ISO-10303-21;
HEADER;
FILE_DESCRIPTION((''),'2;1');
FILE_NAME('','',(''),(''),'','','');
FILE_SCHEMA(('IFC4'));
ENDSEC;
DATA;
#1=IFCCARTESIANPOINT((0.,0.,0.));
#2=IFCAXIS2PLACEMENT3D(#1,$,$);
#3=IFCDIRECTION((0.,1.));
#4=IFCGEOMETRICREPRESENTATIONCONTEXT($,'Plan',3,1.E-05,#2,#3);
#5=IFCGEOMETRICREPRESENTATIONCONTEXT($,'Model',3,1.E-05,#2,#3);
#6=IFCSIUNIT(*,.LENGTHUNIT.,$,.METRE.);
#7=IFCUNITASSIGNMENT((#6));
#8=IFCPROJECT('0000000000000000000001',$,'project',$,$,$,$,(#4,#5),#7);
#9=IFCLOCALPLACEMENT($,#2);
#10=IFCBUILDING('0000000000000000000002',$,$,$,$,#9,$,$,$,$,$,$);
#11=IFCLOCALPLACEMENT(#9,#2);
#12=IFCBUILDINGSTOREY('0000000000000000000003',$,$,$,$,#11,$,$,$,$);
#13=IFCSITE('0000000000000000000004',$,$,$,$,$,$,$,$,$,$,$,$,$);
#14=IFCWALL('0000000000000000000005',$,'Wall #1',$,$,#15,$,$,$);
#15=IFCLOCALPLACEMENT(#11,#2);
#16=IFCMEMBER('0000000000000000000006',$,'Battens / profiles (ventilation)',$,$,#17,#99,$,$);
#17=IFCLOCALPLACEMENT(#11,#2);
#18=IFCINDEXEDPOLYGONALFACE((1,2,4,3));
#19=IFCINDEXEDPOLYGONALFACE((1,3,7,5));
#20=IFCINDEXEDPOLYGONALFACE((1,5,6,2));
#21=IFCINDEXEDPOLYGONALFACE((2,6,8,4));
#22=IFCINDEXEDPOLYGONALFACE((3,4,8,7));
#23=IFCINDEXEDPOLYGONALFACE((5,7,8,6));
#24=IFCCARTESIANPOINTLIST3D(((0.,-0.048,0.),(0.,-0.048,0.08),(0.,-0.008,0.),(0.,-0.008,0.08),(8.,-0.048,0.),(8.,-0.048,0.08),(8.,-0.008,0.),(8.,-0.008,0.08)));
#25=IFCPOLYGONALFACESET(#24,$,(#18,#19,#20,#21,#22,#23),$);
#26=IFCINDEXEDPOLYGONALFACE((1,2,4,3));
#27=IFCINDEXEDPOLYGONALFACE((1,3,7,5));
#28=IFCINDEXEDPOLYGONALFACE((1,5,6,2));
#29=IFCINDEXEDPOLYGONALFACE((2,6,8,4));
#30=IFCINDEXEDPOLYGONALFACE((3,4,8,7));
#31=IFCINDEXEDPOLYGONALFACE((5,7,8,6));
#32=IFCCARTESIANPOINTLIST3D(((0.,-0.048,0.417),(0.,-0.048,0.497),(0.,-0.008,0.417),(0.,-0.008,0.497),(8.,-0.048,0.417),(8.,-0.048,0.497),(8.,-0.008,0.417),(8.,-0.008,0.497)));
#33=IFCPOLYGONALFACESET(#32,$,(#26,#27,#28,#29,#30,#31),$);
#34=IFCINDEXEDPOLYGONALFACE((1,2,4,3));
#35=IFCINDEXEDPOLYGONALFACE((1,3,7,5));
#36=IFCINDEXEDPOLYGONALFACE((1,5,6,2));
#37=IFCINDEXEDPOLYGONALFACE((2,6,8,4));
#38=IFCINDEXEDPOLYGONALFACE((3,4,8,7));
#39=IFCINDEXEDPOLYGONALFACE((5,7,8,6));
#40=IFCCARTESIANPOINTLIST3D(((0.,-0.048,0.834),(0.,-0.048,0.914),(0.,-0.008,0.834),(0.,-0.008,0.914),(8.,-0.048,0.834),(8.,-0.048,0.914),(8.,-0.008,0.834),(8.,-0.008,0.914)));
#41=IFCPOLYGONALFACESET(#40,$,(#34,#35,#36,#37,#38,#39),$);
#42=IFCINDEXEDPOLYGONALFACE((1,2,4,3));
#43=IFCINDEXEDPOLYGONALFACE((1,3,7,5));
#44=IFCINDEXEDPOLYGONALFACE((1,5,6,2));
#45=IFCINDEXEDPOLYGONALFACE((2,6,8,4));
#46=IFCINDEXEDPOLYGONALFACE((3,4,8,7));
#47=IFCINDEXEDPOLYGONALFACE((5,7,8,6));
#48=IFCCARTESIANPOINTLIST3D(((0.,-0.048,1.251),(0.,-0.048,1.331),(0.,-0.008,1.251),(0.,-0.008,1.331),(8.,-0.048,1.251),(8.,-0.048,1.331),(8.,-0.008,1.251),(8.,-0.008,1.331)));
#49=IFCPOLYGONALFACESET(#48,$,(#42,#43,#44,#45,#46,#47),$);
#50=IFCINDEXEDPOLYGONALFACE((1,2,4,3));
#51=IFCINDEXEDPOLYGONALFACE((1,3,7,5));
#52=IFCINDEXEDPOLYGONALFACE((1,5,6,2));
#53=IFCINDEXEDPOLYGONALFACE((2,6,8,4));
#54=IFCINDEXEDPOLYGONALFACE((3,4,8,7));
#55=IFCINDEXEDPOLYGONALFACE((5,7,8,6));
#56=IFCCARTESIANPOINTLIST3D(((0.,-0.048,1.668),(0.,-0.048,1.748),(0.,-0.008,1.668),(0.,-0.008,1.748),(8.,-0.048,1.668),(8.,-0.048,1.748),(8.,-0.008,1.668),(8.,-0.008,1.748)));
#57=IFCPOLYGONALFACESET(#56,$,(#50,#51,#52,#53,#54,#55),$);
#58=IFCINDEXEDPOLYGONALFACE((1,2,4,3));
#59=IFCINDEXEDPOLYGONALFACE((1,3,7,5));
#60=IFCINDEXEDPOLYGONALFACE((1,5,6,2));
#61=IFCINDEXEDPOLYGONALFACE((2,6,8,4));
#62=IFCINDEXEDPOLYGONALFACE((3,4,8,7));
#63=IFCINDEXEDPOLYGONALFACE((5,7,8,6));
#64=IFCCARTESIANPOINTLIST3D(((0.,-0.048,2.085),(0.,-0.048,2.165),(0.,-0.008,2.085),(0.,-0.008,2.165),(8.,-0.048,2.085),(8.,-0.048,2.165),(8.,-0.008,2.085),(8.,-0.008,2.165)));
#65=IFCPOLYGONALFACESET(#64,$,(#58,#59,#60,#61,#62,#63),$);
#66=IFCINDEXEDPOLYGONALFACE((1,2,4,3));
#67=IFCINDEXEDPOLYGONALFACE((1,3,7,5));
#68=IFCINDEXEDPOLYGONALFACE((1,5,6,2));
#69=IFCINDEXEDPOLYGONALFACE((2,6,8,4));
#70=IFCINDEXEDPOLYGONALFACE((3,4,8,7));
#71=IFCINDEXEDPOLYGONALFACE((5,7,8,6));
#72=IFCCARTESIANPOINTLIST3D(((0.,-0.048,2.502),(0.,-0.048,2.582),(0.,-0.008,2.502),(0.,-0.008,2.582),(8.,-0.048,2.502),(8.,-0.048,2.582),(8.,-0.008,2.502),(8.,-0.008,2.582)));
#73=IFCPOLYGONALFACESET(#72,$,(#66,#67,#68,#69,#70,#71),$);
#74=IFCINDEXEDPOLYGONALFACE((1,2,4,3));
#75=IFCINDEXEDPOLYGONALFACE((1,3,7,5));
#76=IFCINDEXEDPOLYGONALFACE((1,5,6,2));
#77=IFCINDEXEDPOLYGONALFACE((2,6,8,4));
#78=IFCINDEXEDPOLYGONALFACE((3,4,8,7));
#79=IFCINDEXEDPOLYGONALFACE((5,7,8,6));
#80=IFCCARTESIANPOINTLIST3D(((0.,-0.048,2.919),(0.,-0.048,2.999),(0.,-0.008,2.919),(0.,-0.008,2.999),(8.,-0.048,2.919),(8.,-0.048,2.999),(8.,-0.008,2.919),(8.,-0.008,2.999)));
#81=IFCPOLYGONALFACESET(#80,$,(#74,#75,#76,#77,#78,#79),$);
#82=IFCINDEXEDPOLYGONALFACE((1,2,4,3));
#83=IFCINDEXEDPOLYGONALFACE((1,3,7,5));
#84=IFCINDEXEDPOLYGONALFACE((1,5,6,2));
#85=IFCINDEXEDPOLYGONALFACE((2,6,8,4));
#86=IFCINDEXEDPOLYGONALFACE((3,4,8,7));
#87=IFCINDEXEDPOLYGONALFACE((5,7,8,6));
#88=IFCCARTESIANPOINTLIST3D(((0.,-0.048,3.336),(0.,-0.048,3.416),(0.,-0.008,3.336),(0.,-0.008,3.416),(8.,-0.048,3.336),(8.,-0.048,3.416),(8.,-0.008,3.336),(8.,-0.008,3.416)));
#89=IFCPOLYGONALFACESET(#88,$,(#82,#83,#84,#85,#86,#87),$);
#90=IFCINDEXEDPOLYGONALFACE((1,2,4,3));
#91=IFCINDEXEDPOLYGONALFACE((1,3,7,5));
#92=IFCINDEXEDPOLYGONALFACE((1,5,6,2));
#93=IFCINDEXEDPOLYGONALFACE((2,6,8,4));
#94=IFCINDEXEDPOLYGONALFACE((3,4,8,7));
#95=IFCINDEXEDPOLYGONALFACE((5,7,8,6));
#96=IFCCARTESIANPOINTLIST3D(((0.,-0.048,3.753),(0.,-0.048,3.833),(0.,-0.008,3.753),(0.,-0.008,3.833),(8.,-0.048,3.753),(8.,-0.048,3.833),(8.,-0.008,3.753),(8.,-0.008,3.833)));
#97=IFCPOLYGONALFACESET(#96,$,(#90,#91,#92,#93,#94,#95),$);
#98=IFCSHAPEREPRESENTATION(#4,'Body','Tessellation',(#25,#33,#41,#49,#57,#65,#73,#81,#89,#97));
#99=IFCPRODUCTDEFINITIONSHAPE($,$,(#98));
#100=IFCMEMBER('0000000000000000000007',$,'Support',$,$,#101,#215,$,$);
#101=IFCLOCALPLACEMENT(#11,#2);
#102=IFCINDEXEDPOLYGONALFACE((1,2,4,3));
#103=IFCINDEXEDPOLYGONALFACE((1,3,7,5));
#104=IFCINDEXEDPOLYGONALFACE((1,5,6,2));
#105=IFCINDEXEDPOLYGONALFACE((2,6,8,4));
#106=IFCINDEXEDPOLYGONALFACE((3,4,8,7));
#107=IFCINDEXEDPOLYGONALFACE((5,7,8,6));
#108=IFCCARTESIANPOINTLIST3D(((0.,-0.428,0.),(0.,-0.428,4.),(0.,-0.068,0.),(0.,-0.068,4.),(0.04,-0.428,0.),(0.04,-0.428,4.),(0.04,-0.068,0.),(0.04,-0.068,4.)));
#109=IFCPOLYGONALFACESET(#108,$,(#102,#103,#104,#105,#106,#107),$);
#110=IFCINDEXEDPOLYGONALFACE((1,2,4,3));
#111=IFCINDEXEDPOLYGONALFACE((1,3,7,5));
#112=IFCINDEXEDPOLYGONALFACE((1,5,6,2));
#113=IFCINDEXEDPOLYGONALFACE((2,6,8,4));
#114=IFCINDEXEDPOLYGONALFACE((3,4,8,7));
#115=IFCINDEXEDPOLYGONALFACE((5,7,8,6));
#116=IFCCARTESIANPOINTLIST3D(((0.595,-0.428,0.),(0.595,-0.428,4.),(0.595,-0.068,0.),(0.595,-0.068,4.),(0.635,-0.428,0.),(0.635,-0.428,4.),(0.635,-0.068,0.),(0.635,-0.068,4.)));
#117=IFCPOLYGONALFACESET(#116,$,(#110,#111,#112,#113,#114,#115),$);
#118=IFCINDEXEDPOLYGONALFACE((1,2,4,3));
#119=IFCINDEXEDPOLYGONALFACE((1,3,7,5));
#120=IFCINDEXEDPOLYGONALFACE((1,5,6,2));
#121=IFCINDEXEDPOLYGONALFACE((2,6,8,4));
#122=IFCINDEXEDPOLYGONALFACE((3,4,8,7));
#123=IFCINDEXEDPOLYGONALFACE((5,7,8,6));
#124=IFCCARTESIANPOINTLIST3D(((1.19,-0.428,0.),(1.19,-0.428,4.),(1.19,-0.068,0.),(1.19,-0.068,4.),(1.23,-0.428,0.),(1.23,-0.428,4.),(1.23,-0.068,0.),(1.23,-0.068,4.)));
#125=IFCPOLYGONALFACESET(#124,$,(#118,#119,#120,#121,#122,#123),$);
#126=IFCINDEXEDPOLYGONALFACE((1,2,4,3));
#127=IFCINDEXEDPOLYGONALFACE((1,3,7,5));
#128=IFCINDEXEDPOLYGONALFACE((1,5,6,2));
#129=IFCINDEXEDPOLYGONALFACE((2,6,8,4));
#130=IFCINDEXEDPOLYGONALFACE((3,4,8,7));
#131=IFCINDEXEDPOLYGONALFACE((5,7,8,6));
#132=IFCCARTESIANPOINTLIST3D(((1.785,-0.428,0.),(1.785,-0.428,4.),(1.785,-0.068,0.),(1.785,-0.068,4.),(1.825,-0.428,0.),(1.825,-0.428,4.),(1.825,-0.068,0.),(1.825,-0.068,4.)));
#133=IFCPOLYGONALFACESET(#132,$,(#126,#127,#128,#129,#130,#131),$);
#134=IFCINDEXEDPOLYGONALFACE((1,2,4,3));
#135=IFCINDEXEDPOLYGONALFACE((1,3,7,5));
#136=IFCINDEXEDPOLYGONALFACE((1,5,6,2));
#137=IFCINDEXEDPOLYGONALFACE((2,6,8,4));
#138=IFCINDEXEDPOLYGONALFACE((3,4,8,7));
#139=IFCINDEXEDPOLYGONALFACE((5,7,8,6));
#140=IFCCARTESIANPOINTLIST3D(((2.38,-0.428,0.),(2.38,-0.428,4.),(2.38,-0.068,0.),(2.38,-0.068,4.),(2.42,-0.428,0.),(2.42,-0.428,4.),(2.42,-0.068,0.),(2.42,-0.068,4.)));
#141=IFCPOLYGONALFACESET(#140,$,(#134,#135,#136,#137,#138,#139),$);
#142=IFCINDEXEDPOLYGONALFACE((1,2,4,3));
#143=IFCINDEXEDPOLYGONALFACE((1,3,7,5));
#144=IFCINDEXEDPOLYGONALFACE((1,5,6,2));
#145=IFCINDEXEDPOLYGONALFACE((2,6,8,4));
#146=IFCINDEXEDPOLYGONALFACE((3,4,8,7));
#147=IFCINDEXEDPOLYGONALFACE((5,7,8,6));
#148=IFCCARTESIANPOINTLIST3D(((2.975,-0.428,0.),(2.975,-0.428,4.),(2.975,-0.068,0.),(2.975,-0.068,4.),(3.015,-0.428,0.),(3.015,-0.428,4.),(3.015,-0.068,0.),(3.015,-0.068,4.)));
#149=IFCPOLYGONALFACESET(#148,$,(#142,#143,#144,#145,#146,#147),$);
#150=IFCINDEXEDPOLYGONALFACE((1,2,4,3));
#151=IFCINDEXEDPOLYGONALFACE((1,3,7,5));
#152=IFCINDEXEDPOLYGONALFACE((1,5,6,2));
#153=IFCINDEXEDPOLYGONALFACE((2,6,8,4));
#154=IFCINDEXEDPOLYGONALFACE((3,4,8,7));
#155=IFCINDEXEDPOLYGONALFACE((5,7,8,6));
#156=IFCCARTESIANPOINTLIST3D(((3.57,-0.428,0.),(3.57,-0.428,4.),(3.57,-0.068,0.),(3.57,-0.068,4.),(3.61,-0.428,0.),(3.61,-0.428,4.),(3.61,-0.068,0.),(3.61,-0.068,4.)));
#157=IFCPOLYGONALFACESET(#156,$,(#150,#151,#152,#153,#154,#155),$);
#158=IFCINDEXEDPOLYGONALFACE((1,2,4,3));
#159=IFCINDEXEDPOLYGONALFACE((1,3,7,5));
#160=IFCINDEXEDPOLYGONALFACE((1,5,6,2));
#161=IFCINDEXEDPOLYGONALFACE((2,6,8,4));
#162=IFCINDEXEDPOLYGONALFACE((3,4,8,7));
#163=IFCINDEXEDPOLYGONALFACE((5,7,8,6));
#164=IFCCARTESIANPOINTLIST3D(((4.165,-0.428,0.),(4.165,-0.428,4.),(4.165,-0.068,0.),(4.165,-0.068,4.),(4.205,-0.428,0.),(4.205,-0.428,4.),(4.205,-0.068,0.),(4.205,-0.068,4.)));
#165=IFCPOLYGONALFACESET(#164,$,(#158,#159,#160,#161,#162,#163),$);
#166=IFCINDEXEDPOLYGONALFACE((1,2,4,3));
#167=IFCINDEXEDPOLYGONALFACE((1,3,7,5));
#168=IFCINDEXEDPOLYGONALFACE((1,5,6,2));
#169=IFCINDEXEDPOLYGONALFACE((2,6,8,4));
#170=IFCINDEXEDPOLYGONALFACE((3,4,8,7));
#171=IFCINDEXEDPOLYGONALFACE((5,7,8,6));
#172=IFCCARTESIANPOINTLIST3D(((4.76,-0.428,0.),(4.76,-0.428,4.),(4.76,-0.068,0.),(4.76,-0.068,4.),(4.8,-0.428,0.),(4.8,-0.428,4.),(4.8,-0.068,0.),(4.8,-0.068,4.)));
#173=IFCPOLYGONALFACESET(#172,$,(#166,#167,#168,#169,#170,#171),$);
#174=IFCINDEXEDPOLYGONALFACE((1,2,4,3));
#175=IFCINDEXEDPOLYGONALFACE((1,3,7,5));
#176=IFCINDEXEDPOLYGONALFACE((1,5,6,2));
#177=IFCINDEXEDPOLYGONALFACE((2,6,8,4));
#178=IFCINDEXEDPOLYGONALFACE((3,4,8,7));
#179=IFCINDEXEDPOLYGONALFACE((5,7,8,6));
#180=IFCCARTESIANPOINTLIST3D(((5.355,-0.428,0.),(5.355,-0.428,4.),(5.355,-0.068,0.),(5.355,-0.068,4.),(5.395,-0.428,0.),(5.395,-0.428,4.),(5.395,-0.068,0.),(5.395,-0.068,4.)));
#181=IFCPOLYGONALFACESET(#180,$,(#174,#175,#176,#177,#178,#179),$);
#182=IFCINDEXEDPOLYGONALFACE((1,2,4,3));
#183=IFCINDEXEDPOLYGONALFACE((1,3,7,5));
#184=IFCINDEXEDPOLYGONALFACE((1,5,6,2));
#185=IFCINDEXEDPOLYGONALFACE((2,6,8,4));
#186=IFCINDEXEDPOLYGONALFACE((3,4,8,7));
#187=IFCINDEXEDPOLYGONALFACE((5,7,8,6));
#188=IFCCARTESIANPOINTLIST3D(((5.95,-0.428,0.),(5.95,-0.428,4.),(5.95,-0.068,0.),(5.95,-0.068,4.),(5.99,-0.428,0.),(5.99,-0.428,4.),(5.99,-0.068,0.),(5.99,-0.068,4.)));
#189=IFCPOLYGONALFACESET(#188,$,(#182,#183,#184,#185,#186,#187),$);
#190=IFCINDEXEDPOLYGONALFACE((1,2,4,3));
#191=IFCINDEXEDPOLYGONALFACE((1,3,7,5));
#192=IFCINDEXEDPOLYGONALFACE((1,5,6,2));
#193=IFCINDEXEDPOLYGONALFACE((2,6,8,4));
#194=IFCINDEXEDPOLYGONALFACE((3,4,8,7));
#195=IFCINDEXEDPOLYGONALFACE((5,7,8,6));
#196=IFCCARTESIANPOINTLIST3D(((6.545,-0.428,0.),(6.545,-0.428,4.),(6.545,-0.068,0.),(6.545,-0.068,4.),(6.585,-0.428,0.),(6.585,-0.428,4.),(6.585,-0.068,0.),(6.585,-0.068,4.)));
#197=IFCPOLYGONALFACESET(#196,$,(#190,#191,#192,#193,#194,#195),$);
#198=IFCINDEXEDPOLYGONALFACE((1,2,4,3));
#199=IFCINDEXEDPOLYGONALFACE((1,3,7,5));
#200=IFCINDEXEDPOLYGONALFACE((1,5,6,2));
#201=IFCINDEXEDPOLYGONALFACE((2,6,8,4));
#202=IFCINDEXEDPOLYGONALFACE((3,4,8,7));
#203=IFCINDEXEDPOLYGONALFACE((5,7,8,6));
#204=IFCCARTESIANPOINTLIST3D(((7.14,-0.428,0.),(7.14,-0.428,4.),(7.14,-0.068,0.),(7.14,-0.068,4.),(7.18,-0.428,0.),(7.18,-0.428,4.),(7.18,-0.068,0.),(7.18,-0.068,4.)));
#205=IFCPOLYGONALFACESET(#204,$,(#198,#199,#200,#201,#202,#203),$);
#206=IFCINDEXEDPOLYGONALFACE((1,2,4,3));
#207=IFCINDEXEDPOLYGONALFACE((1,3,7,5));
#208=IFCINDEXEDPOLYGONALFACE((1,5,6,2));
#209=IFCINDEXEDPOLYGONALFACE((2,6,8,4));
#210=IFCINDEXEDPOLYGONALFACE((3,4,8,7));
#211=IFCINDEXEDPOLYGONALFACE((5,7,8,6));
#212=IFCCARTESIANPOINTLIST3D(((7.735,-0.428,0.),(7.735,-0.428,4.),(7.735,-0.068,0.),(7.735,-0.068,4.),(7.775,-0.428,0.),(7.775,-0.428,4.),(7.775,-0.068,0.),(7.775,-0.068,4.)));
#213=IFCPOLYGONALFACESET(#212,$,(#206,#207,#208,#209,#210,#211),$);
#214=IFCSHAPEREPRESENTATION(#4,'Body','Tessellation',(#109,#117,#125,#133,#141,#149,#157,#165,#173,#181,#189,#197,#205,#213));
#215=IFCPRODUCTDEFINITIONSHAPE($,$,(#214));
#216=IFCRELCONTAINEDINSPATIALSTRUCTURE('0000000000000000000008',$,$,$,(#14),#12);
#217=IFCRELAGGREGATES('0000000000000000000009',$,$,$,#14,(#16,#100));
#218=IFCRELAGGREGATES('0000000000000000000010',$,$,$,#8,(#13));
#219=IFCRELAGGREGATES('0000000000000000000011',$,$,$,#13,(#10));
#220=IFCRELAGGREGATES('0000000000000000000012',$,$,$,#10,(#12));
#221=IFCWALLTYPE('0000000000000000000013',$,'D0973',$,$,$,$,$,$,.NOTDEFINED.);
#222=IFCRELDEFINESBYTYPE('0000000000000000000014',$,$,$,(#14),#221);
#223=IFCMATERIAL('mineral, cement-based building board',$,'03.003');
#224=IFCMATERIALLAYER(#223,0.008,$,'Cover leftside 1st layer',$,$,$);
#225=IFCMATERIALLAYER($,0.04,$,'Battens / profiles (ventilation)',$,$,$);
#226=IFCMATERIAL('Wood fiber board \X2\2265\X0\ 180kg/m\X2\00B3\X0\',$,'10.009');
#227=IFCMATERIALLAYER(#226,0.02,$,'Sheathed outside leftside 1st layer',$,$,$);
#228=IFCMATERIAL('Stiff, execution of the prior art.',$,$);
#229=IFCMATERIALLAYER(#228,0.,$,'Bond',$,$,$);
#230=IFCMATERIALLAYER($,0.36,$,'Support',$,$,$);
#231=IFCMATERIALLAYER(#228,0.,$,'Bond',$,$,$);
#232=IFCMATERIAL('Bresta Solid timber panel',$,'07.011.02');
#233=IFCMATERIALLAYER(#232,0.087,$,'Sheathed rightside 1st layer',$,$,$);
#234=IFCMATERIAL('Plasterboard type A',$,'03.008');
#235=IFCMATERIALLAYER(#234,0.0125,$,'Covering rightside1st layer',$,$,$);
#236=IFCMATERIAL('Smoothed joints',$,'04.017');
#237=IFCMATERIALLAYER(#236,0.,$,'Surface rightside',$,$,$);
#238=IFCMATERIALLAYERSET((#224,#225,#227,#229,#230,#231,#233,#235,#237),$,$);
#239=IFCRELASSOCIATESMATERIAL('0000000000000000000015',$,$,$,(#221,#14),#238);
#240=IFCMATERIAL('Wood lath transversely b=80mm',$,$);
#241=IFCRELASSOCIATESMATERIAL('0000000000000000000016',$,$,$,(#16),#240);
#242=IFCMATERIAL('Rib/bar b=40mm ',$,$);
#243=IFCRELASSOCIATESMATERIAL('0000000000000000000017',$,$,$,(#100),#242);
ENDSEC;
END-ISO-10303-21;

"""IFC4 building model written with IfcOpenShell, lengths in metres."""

from ifc_helpers import new_model, si_unit, direction, frame, frame_2d, origin, place, context, project, spatial, rectangle, extrude, material, layer, layer_set, type_object, element, aggregate, save


model = new_model("IFC4")

# Units and contexts
plan_context = context("Plan", 3, precision=1e-05, world=origin(), true_north=direction((0.0, 1.0)))
model_context = context("Model", 3, precision=1e-05, world=origin(), true_north=direction((0.0, 1.0)))
ifc_project = project(units=[si_unit("LENGTHUNIT", "METRE")], contexts=[plan_context, model_context])

# Site, building, storey
site = spatial("IfcSite", under=ifc_project)
building_placement = place(None, origin())
building = spatial("IfcBuilding", under=site, at=building_placement)
storey_placement = place(building_placement, origin())
storey = spatial("IfcBuildingStorey", under=building, at=storey_placement)

# Wall, members
ifc_material_1 = material(Name="mineral, cement-based building board", Category="03.003")
ifc_layer_1 = layer(ifc_material_1, 0.008, Name="Cover leftside 1st layer")
ifc_layer_2 = layer(None, 0.04, Name="Battens / profiles (ventilation)")
ifc_material_2 = material(Name="Wood fiber board ≥ 180kg/m³", Category="10.009")
ifc_layer_3 = layer(ifc_material_2, 0.02, Name="Sheathed outside leftside 1st layer")
ifc_material_3 = material(Name="Stiff, execution of the prior art.")
ifc_layer_4 = layer(ifc_material_3, 0.0, Name="Bond")
ifc_layer_5 = layer(None, 0.36, Name="Support")
ifc_layer_6 = layer(ifc_material_3, 0.0, Name="Bond")
ifc_material_4 = material(Name="Bresta Solid timber panel", Category="07.011.02")
ifc_layer_7 = layer(ifc_material_4, 0.087, Name="Sheathed rightside 1st layer")
ifc_material_5 = material(Name="Plasterboard type A", Category="03.008")
ifc_layer_8 = layer(ifc_material_5, 0.0125, Name="Covering rightside1st layer")
ifc_material_6 = material(Name="Smoothed joints", Category="04.017")
ifc_layer_9 = layer(ifc_material_6, 0.0, Name="Surface rightside")
ifc_layer_set = layer_set([ifc_layer_1, ifc_layer_2, ifc_layer_3, ifc_layer_4, ifc_layer_5, ifc_layer_6, ifc_layer_7, ifc_layer_8, ifc_layer_9])
wall_type = type_object("IfcWallType", Name="D0973", PredefinedType="NOTDEFINED", material=ifc_layer_set)
wall_placement = place(None, frame((0.0, 0.0, 0.0), z_axis=(0.0, -1.0, 0.0), x_axis=(1.0, 0.0, 0.0)))
wall = element("IfcWall", 1, at=wall_placement, inside=storey, type_object=wall_type, material=ifc_layer_set, Name="Wall #1")
ifc_material_7 = material(Name="Wood lath transversely b=80mm")
member_1_placement = place(wall_placement, origin())
member_1 = element("IfcMember", 2, at=member_1_placement, material=ifc_material_7, Name="Battens / profiles (ventilation)", context=plan_context, shape_type="SweptSolid", body=[
    extrude(rectangle(XDim=0.08, YDim=0.04, at=frame_2d((0.04, 0.02), x_axis=(1.0, 0.0))), frame((0.0, 0.0, 0.008), z_axis=(1.0, 0.0, 0.0), x_axis=(0.0, 1.0, 0.0)), (0.0, 0.0, 1.0), 8.0),
    extrude(rectangle(XDim=0.08, YDim=0.04, at=frame_2d((0.04, 0.02), x_axis=(1.0, 0.0))), frame((0.0, 0.417, 0.008), z_axis=(1.0, 0.0, 0.0), x_axis=(0.0, 1.0, 0.0)), (0.0, 0.0, 1.0), 8.0),
    extrude(rectangle(XDim=0.08, YDim=0.04, at=frame_2d((0.04, 0.02), x_axis=(1.0, 0.0))), frame((0.0, 0.834, 0.008), z_axis=(1.0, 0.0, 0.0), x_axis=(0.0, 1.0, 0.0)), (0.0, 0.0, 1.0), 8.0),
    extrude(rectangle(XDim=0.08, YDim=0.04, at=frame_2d((0.04, 0.02), x_axis=(1.0, 0.0))), frame((0.0, 1.251, 0.008), z_axis=(1.0, 0.0, 0.0), x_axis=(0.0, 1.0, 0.0)), (0.0, 0.0, 1.0), 8.0),
    extrude(rectangle(XDim=0.08, YDim=0.04, at=frame_2d((0.04, 0.02), x_axis=(1.0, 0.0))), frame((0.0, 1.668, 0.008), z_axis=(1.0, 0.0, 0.0), x_axis=(0.0, 1.0, 0.0)), (0.0, 0.0, 1.0), 8.0),
    extrude(rectangle(XDim=0.08, YDim=0.04, at=frame_2d((0.04, 0.02), x_axis=(1.0, 0.0))), frame((0.0, 2.085, 0.008), z_axis=(1.0, 0.0, 0.0), x_axis=(0.0, 1.0, 0.0)), (0.0, 0.0, 1.0), 8.0),
    extrude(rectangle(XDim=0.08, YDim=0.04, at=frame_2d((0.04, 0.02), x_axis=(1.0, 0.0))), frame((0.0, 2.502, 0.008), z_axis=(1.0, 0.0, 0.0), x_axis=(0.0, 1.0, 0.0)), (0.0, 0.0, 1.0), 8.0),
    extrude(rectangle(XDim=0.08, YDim=0.04, at=frame_2d((0.04, 0.02), x_axis=(1.0, 0.0))), frame((0.0, 2.919, 0.008), z_axis=(1.0, 0.0, 0.0), x_axis=(0.0, 1.0, 0.0)), (0.0, 0.0, 1.0), 8.0),
    extrude(rectangle(XDim=0.08, YDim=0.04, at=frame_2d((0.04, 0.02), x_axis=(1.0, 0.0))), frame((0.0, 3.336, 0.008), z_axis=(1.0, 0.0, 0.0), x_axis=(0.0, 1.0, 0.0)), (0.0, 0.0, 1.0), 8.0),
    extrude(rectangle(XDim=0.08, YDim=0.04, at=frame_2d((0.04, 0.02), x_axis=(1.0, 0.0))), frame((0.0, 3.753, 0.008), z_axis=(1.0, 0.0, 0.0), x_axis=(0.0, 1.0, 0.0)), (0.0, 0.0, 1.0), 8.0),
])
ifc_material_8 = material(Name="Rib/bar b=40mm ")
member_2_placement = place(wall_placement, origin())
member_2 = element("IfcMember", 3, at=member_2_placement, material=ifc_material_8, Name="Support", context=plan_context, shape_type="SweptSolid", body=[
    extrude(rectangle(XDim=0.04, YDim=0.36, at=frame_2d((0.02, 0.18), x_axis=(1.0, 0.0))), frame((0.0, 4.0, 0.068), z_axis=(0.0, -1.0, 0.0), x_axis=(1.0, 0.0, 0.0)), (0.0, 0.0, 1.0), 4.0),
    extrude(rectangle(XDim=0.04, YDim=0.36, at=frame_2d((0.02, 0.18), x_axis=(1.0, 0.0))), frame((0.595, 4.0, 0.068), z_axis=(0.0, -1.0, 0.0), x_axis=(1.0, 0.0, 0.0)), (0.0, 0.0, 1.0), 4.0),
    extrude(rectangle(XDim=0.04, YDim=0.36, at=frame_2d((0.02, 0.18), x_axis=(1.0, 0.0))), frame((1.19, 4.0, 0.068), z_axis=(0.0, -1.0, 0.0), x_axis=(1.0, 0.0, 0.0)), (0.0, 0.0, 1.0), 4.0),
    extrude(rectangle(XDim=0.04, YDim=0.36, at=frame_2d((0.02, 0.18), x_axis=(1.0, 0.0))), frame((1.785, 4.0, 0.068), z_axis=(0.0, -1.0, 0.0), x_axis=(1.0, 0.0, 0.0)), (0.0, 0.0, 1.0), 4.0),
    extrude(rectangle(XDim=0.04, YDim=0.36, at=frame_2d((0.02, 0.18), x_axis=(1.0, 0.0))), frame((2.38, 4.0, 0.068), z_axis=(0.0, -1.0, 0.0), x_axis=(1.0, 0.0, 0.0)), (0.0, 0.0, 1.0), 4.0),
    extrude(rectangle(XDim=0.04, YDim=0.36, at=frame_2d((0.02, 0.18), x_axis=(1.0, 0.0))), frame((2.975, 4.0, 0.068), z_axis=(0.0, -1.0, 0.0), x_axis=(1.0, 0.0, 0.0)), (0.0, 0.0, 1.0), 4.0),
    extrude(rectangle(XDim=0.04, YDim=0.36, at=frame_2d((0.02, 0.18), x_axis=(1.0, 0.0))), frame((3.57, 4.0, 0.068), z_axis=(0.0, -1.0, 0.0), x_axis=(1.0, 0.0, 0.0)), (0.0, 0.0, 1.0), 4.0),
    extrude(rectangle(XDim=0.04, YDim=0.36, at=frame_2d((0.02, 0.18), x_axis=(1.0, 0.0))), frame((4.165, 4.0, 0.068), z_axis=(0.0, -1.0, 0.0), x_axis=(1.0, 0.0, 0.0)), (0.0, 0.0, 1.0), 4.0),
    extrude(rectangle(XDim=0.04, YDim=0.36, at=frame_2d((0.02, 0.18), x_axis=(1.0, 0.0))), frame((4.76, 4.0, 0.068), z_axis=(0.0, -1.0, 0.0), x_axis=(1.0, 0.0, 0.0)), (0.0, 0.0, 1.0), 4.0),
    extrude(rectangle(XDim=0.04, YDim=0.36, at=frame_2d((0.02, 0.18), x_axis=(1.0, 0.0))), frame((5.355, 4.0, 0.068), z_axis=(0.0, -1.0, 0.0), x_axis=(1.0, 0.0, 0.0)), (0.0, 0.0, 1.0), 4.0),
    extrude(rectangle(XDim=0.04, YDim=0.36, at=frame_2d((0.02, 0.18), x_axis=(1.0, 0.0))), frame((5.95, 4.0, 0.068), z_axis=(0.0, -1.0, 0.0), x_axis=(1.0, 0.0, 0.0)), (0.0, 0.0, 1.0), 4.0),
    extrude(rectangle(XDim=0.04, YDim=0.36, at=frame_2d((0.02, 0.18), x_axis=(1.0, 0.0))), frame((6.545, 4.0, 0.068), z_axis=(0.0, -1.0, 0.0), x_axis=(1.0, 0.0, 0.0)), (0.0, 0.0, 1.0), 4.0),
    extrude(rectangle(XDim=0.04, YDim=0.36, at=frame_2d((0.02, 0.18), x_axis=(1.0, 0.0))), frame((7.14, 4.0, 0.068), z_axis=(0.0, -1.0, 0.0), x_axis=(1.0, 0.0, 0.0)), (0.0, 0.0, 1.0), 4.0),
    extrude(rectangle(XDim=0.04, YDim=0.36, at=frame_2d((0.02, 0.18), x_axis=(1.0, 0.0))), frame((7.735, 4.0, 0.068), z_axis=(0.0, -1.0, 0.0), x_axis=(1.0, 0.0, 0.0)), (0.0, 0.0, 1.0), 4.0),
])
aggregate(wall, [member_1, member_2])

save(model, "model.ifc")
